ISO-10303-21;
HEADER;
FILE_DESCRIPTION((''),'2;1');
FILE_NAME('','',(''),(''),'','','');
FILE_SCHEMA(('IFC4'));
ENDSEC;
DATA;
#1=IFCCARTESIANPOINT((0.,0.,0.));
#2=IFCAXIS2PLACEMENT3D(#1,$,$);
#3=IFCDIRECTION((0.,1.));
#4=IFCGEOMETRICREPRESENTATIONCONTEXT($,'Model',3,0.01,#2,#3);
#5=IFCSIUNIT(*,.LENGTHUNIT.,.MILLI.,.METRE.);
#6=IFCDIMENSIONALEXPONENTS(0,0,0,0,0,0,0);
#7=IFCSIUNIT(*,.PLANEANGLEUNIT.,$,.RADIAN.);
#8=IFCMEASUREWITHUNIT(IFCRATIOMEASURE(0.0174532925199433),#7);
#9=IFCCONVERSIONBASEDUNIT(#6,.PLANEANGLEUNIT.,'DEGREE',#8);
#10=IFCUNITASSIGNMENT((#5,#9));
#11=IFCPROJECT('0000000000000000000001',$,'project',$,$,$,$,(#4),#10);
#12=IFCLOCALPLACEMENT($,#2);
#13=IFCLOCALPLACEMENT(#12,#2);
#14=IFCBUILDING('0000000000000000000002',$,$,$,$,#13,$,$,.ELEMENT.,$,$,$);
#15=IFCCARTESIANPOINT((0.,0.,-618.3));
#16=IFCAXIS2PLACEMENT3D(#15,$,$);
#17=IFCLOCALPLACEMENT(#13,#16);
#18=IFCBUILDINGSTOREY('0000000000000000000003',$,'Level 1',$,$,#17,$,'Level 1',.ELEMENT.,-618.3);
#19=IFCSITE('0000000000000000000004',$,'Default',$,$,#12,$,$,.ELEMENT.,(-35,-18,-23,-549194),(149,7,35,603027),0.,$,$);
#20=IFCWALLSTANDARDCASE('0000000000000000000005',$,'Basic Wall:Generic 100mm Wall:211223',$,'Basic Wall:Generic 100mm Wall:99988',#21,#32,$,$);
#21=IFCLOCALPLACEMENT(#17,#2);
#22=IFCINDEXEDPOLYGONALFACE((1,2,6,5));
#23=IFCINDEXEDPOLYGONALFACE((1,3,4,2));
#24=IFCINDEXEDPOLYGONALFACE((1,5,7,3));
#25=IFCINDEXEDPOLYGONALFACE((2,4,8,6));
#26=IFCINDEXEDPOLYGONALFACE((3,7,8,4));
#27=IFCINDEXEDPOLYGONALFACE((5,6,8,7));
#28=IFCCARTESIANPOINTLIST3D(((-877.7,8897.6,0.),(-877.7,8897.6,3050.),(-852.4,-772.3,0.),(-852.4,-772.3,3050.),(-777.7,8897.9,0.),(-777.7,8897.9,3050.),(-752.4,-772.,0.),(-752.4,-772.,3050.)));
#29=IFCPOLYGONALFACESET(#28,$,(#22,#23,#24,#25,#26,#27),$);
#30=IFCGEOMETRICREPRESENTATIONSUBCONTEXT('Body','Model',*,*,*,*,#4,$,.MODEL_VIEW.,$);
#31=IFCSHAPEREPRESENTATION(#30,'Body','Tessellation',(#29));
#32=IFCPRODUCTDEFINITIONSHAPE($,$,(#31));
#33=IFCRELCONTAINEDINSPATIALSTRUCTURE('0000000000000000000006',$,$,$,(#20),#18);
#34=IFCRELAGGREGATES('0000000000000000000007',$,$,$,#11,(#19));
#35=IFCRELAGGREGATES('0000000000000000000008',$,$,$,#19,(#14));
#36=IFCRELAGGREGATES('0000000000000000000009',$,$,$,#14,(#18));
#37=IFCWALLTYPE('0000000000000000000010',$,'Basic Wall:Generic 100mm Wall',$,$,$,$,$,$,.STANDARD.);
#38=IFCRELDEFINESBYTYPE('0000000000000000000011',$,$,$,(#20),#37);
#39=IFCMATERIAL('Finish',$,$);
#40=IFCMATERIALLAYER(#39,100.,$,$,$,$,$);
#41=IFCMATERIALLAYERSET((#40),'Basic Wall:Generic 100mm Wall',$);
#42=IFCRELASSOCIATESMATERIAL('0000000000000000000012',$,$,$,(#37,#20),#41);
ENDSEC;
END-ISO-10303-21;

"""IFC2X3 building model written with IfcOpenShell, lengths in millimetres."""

from ifc_helpers import new_model, entity, si_unit, converted_unit, direction, frame, frame_2d, origin, place, context, subcontext, project, spatial, rectangle, extrude, material, layer, layer_set, layer_usage, type_object, element, save


model = new_model("IFC2X3")

# Units and contexts
model_context = context("Model", 3, precision=0.01, world=origin(), true_north=direction((0.0, 1.0)))
body_context = subcontext(model_context, "Body", "Model", "MODEL_VIEW")
ifc_project = project(units=[si_unit("LENGTHUNIT", "METRE", prefix="MILLI"), converted_unit("PLANEANGLEUNIT", "DEGREE", entity("IfcRatioMeasure", 0.0174532925199433), si_unit("PLANEANGLEUNIT", "RADIAN"), dimensions=[0, 0, 0, 0, 0, 0, 0])], contexts=[model_context])

# Site, building, storey
site_placement = place(None, origin())
site = spatial("IfcSite", under=ifc_project, at=site_placement, Name="Default", CompositionType="ELEMENT", RefLatitude=(-35, -18, -23, -549194), RefLongitude=(149, 7, 35, 603027), RefElevation=0.0)
building_placement = place(site_placement, origin())
building = spatial("IfcBuilding", under=site, at=building_placement, CompositionType="ELEMENT")
storey_placement = place(building_placement, frame((0.0, 0.0, -618.3)))
storey = spatial("IfcBuildingStorey", under=building, at=storey_placement, Name="Level 1", LongName="Level 1", CompositionType="ELEMENT", Elevation=-618.3)

# Shared definitions
ifc_material_1 = material(Name="Finish")
ifc_layer_1 = layer(ifc_material_1, 100.0)
ifc_layer_set_1 = layer_set([ifc_layer_1], Name="Basic Wall:Generic 100mm Wall")
wall_type = type_object("IfcWallType", Name="Basic Wall:Generic 100mm Wall", PredefinedType="STANDARD", material=ifc_layer_set_1)

# Wall
ifc_layer_usage_1 = layer_usage(ifc_layer_set_1, "AXIS2", "NEGATIVE", 50.0)
wall_1_placement = place(storey_placement, frame((-802.4, -772.1, 0.0), z_axis=(0.0, 0.0, 1.0), x_axis=(-0.002618, 0.999997, 0.0)))
element("IfcWallStandardCase", 1, at=wall_1_placement, inside=storey, type_object=wall_type, material=ifc_layer_usage_1, Name="Basic Wall:Generic 100mm Wall:211223", ObjectType="Basic Wall:Generic 100mm Wall:99988", context=body_context, shape_type="SweptSolid", body=[
    extrude(rectangle(XDim=9669.9, YDim=100.0, at=frame_2d((4835.0, 0.0), x_axis=(-1.0, 0.0))), origin(), (0.0, 0.0, 1.0), 3050.0),
])

save(model, "model.ifc")
